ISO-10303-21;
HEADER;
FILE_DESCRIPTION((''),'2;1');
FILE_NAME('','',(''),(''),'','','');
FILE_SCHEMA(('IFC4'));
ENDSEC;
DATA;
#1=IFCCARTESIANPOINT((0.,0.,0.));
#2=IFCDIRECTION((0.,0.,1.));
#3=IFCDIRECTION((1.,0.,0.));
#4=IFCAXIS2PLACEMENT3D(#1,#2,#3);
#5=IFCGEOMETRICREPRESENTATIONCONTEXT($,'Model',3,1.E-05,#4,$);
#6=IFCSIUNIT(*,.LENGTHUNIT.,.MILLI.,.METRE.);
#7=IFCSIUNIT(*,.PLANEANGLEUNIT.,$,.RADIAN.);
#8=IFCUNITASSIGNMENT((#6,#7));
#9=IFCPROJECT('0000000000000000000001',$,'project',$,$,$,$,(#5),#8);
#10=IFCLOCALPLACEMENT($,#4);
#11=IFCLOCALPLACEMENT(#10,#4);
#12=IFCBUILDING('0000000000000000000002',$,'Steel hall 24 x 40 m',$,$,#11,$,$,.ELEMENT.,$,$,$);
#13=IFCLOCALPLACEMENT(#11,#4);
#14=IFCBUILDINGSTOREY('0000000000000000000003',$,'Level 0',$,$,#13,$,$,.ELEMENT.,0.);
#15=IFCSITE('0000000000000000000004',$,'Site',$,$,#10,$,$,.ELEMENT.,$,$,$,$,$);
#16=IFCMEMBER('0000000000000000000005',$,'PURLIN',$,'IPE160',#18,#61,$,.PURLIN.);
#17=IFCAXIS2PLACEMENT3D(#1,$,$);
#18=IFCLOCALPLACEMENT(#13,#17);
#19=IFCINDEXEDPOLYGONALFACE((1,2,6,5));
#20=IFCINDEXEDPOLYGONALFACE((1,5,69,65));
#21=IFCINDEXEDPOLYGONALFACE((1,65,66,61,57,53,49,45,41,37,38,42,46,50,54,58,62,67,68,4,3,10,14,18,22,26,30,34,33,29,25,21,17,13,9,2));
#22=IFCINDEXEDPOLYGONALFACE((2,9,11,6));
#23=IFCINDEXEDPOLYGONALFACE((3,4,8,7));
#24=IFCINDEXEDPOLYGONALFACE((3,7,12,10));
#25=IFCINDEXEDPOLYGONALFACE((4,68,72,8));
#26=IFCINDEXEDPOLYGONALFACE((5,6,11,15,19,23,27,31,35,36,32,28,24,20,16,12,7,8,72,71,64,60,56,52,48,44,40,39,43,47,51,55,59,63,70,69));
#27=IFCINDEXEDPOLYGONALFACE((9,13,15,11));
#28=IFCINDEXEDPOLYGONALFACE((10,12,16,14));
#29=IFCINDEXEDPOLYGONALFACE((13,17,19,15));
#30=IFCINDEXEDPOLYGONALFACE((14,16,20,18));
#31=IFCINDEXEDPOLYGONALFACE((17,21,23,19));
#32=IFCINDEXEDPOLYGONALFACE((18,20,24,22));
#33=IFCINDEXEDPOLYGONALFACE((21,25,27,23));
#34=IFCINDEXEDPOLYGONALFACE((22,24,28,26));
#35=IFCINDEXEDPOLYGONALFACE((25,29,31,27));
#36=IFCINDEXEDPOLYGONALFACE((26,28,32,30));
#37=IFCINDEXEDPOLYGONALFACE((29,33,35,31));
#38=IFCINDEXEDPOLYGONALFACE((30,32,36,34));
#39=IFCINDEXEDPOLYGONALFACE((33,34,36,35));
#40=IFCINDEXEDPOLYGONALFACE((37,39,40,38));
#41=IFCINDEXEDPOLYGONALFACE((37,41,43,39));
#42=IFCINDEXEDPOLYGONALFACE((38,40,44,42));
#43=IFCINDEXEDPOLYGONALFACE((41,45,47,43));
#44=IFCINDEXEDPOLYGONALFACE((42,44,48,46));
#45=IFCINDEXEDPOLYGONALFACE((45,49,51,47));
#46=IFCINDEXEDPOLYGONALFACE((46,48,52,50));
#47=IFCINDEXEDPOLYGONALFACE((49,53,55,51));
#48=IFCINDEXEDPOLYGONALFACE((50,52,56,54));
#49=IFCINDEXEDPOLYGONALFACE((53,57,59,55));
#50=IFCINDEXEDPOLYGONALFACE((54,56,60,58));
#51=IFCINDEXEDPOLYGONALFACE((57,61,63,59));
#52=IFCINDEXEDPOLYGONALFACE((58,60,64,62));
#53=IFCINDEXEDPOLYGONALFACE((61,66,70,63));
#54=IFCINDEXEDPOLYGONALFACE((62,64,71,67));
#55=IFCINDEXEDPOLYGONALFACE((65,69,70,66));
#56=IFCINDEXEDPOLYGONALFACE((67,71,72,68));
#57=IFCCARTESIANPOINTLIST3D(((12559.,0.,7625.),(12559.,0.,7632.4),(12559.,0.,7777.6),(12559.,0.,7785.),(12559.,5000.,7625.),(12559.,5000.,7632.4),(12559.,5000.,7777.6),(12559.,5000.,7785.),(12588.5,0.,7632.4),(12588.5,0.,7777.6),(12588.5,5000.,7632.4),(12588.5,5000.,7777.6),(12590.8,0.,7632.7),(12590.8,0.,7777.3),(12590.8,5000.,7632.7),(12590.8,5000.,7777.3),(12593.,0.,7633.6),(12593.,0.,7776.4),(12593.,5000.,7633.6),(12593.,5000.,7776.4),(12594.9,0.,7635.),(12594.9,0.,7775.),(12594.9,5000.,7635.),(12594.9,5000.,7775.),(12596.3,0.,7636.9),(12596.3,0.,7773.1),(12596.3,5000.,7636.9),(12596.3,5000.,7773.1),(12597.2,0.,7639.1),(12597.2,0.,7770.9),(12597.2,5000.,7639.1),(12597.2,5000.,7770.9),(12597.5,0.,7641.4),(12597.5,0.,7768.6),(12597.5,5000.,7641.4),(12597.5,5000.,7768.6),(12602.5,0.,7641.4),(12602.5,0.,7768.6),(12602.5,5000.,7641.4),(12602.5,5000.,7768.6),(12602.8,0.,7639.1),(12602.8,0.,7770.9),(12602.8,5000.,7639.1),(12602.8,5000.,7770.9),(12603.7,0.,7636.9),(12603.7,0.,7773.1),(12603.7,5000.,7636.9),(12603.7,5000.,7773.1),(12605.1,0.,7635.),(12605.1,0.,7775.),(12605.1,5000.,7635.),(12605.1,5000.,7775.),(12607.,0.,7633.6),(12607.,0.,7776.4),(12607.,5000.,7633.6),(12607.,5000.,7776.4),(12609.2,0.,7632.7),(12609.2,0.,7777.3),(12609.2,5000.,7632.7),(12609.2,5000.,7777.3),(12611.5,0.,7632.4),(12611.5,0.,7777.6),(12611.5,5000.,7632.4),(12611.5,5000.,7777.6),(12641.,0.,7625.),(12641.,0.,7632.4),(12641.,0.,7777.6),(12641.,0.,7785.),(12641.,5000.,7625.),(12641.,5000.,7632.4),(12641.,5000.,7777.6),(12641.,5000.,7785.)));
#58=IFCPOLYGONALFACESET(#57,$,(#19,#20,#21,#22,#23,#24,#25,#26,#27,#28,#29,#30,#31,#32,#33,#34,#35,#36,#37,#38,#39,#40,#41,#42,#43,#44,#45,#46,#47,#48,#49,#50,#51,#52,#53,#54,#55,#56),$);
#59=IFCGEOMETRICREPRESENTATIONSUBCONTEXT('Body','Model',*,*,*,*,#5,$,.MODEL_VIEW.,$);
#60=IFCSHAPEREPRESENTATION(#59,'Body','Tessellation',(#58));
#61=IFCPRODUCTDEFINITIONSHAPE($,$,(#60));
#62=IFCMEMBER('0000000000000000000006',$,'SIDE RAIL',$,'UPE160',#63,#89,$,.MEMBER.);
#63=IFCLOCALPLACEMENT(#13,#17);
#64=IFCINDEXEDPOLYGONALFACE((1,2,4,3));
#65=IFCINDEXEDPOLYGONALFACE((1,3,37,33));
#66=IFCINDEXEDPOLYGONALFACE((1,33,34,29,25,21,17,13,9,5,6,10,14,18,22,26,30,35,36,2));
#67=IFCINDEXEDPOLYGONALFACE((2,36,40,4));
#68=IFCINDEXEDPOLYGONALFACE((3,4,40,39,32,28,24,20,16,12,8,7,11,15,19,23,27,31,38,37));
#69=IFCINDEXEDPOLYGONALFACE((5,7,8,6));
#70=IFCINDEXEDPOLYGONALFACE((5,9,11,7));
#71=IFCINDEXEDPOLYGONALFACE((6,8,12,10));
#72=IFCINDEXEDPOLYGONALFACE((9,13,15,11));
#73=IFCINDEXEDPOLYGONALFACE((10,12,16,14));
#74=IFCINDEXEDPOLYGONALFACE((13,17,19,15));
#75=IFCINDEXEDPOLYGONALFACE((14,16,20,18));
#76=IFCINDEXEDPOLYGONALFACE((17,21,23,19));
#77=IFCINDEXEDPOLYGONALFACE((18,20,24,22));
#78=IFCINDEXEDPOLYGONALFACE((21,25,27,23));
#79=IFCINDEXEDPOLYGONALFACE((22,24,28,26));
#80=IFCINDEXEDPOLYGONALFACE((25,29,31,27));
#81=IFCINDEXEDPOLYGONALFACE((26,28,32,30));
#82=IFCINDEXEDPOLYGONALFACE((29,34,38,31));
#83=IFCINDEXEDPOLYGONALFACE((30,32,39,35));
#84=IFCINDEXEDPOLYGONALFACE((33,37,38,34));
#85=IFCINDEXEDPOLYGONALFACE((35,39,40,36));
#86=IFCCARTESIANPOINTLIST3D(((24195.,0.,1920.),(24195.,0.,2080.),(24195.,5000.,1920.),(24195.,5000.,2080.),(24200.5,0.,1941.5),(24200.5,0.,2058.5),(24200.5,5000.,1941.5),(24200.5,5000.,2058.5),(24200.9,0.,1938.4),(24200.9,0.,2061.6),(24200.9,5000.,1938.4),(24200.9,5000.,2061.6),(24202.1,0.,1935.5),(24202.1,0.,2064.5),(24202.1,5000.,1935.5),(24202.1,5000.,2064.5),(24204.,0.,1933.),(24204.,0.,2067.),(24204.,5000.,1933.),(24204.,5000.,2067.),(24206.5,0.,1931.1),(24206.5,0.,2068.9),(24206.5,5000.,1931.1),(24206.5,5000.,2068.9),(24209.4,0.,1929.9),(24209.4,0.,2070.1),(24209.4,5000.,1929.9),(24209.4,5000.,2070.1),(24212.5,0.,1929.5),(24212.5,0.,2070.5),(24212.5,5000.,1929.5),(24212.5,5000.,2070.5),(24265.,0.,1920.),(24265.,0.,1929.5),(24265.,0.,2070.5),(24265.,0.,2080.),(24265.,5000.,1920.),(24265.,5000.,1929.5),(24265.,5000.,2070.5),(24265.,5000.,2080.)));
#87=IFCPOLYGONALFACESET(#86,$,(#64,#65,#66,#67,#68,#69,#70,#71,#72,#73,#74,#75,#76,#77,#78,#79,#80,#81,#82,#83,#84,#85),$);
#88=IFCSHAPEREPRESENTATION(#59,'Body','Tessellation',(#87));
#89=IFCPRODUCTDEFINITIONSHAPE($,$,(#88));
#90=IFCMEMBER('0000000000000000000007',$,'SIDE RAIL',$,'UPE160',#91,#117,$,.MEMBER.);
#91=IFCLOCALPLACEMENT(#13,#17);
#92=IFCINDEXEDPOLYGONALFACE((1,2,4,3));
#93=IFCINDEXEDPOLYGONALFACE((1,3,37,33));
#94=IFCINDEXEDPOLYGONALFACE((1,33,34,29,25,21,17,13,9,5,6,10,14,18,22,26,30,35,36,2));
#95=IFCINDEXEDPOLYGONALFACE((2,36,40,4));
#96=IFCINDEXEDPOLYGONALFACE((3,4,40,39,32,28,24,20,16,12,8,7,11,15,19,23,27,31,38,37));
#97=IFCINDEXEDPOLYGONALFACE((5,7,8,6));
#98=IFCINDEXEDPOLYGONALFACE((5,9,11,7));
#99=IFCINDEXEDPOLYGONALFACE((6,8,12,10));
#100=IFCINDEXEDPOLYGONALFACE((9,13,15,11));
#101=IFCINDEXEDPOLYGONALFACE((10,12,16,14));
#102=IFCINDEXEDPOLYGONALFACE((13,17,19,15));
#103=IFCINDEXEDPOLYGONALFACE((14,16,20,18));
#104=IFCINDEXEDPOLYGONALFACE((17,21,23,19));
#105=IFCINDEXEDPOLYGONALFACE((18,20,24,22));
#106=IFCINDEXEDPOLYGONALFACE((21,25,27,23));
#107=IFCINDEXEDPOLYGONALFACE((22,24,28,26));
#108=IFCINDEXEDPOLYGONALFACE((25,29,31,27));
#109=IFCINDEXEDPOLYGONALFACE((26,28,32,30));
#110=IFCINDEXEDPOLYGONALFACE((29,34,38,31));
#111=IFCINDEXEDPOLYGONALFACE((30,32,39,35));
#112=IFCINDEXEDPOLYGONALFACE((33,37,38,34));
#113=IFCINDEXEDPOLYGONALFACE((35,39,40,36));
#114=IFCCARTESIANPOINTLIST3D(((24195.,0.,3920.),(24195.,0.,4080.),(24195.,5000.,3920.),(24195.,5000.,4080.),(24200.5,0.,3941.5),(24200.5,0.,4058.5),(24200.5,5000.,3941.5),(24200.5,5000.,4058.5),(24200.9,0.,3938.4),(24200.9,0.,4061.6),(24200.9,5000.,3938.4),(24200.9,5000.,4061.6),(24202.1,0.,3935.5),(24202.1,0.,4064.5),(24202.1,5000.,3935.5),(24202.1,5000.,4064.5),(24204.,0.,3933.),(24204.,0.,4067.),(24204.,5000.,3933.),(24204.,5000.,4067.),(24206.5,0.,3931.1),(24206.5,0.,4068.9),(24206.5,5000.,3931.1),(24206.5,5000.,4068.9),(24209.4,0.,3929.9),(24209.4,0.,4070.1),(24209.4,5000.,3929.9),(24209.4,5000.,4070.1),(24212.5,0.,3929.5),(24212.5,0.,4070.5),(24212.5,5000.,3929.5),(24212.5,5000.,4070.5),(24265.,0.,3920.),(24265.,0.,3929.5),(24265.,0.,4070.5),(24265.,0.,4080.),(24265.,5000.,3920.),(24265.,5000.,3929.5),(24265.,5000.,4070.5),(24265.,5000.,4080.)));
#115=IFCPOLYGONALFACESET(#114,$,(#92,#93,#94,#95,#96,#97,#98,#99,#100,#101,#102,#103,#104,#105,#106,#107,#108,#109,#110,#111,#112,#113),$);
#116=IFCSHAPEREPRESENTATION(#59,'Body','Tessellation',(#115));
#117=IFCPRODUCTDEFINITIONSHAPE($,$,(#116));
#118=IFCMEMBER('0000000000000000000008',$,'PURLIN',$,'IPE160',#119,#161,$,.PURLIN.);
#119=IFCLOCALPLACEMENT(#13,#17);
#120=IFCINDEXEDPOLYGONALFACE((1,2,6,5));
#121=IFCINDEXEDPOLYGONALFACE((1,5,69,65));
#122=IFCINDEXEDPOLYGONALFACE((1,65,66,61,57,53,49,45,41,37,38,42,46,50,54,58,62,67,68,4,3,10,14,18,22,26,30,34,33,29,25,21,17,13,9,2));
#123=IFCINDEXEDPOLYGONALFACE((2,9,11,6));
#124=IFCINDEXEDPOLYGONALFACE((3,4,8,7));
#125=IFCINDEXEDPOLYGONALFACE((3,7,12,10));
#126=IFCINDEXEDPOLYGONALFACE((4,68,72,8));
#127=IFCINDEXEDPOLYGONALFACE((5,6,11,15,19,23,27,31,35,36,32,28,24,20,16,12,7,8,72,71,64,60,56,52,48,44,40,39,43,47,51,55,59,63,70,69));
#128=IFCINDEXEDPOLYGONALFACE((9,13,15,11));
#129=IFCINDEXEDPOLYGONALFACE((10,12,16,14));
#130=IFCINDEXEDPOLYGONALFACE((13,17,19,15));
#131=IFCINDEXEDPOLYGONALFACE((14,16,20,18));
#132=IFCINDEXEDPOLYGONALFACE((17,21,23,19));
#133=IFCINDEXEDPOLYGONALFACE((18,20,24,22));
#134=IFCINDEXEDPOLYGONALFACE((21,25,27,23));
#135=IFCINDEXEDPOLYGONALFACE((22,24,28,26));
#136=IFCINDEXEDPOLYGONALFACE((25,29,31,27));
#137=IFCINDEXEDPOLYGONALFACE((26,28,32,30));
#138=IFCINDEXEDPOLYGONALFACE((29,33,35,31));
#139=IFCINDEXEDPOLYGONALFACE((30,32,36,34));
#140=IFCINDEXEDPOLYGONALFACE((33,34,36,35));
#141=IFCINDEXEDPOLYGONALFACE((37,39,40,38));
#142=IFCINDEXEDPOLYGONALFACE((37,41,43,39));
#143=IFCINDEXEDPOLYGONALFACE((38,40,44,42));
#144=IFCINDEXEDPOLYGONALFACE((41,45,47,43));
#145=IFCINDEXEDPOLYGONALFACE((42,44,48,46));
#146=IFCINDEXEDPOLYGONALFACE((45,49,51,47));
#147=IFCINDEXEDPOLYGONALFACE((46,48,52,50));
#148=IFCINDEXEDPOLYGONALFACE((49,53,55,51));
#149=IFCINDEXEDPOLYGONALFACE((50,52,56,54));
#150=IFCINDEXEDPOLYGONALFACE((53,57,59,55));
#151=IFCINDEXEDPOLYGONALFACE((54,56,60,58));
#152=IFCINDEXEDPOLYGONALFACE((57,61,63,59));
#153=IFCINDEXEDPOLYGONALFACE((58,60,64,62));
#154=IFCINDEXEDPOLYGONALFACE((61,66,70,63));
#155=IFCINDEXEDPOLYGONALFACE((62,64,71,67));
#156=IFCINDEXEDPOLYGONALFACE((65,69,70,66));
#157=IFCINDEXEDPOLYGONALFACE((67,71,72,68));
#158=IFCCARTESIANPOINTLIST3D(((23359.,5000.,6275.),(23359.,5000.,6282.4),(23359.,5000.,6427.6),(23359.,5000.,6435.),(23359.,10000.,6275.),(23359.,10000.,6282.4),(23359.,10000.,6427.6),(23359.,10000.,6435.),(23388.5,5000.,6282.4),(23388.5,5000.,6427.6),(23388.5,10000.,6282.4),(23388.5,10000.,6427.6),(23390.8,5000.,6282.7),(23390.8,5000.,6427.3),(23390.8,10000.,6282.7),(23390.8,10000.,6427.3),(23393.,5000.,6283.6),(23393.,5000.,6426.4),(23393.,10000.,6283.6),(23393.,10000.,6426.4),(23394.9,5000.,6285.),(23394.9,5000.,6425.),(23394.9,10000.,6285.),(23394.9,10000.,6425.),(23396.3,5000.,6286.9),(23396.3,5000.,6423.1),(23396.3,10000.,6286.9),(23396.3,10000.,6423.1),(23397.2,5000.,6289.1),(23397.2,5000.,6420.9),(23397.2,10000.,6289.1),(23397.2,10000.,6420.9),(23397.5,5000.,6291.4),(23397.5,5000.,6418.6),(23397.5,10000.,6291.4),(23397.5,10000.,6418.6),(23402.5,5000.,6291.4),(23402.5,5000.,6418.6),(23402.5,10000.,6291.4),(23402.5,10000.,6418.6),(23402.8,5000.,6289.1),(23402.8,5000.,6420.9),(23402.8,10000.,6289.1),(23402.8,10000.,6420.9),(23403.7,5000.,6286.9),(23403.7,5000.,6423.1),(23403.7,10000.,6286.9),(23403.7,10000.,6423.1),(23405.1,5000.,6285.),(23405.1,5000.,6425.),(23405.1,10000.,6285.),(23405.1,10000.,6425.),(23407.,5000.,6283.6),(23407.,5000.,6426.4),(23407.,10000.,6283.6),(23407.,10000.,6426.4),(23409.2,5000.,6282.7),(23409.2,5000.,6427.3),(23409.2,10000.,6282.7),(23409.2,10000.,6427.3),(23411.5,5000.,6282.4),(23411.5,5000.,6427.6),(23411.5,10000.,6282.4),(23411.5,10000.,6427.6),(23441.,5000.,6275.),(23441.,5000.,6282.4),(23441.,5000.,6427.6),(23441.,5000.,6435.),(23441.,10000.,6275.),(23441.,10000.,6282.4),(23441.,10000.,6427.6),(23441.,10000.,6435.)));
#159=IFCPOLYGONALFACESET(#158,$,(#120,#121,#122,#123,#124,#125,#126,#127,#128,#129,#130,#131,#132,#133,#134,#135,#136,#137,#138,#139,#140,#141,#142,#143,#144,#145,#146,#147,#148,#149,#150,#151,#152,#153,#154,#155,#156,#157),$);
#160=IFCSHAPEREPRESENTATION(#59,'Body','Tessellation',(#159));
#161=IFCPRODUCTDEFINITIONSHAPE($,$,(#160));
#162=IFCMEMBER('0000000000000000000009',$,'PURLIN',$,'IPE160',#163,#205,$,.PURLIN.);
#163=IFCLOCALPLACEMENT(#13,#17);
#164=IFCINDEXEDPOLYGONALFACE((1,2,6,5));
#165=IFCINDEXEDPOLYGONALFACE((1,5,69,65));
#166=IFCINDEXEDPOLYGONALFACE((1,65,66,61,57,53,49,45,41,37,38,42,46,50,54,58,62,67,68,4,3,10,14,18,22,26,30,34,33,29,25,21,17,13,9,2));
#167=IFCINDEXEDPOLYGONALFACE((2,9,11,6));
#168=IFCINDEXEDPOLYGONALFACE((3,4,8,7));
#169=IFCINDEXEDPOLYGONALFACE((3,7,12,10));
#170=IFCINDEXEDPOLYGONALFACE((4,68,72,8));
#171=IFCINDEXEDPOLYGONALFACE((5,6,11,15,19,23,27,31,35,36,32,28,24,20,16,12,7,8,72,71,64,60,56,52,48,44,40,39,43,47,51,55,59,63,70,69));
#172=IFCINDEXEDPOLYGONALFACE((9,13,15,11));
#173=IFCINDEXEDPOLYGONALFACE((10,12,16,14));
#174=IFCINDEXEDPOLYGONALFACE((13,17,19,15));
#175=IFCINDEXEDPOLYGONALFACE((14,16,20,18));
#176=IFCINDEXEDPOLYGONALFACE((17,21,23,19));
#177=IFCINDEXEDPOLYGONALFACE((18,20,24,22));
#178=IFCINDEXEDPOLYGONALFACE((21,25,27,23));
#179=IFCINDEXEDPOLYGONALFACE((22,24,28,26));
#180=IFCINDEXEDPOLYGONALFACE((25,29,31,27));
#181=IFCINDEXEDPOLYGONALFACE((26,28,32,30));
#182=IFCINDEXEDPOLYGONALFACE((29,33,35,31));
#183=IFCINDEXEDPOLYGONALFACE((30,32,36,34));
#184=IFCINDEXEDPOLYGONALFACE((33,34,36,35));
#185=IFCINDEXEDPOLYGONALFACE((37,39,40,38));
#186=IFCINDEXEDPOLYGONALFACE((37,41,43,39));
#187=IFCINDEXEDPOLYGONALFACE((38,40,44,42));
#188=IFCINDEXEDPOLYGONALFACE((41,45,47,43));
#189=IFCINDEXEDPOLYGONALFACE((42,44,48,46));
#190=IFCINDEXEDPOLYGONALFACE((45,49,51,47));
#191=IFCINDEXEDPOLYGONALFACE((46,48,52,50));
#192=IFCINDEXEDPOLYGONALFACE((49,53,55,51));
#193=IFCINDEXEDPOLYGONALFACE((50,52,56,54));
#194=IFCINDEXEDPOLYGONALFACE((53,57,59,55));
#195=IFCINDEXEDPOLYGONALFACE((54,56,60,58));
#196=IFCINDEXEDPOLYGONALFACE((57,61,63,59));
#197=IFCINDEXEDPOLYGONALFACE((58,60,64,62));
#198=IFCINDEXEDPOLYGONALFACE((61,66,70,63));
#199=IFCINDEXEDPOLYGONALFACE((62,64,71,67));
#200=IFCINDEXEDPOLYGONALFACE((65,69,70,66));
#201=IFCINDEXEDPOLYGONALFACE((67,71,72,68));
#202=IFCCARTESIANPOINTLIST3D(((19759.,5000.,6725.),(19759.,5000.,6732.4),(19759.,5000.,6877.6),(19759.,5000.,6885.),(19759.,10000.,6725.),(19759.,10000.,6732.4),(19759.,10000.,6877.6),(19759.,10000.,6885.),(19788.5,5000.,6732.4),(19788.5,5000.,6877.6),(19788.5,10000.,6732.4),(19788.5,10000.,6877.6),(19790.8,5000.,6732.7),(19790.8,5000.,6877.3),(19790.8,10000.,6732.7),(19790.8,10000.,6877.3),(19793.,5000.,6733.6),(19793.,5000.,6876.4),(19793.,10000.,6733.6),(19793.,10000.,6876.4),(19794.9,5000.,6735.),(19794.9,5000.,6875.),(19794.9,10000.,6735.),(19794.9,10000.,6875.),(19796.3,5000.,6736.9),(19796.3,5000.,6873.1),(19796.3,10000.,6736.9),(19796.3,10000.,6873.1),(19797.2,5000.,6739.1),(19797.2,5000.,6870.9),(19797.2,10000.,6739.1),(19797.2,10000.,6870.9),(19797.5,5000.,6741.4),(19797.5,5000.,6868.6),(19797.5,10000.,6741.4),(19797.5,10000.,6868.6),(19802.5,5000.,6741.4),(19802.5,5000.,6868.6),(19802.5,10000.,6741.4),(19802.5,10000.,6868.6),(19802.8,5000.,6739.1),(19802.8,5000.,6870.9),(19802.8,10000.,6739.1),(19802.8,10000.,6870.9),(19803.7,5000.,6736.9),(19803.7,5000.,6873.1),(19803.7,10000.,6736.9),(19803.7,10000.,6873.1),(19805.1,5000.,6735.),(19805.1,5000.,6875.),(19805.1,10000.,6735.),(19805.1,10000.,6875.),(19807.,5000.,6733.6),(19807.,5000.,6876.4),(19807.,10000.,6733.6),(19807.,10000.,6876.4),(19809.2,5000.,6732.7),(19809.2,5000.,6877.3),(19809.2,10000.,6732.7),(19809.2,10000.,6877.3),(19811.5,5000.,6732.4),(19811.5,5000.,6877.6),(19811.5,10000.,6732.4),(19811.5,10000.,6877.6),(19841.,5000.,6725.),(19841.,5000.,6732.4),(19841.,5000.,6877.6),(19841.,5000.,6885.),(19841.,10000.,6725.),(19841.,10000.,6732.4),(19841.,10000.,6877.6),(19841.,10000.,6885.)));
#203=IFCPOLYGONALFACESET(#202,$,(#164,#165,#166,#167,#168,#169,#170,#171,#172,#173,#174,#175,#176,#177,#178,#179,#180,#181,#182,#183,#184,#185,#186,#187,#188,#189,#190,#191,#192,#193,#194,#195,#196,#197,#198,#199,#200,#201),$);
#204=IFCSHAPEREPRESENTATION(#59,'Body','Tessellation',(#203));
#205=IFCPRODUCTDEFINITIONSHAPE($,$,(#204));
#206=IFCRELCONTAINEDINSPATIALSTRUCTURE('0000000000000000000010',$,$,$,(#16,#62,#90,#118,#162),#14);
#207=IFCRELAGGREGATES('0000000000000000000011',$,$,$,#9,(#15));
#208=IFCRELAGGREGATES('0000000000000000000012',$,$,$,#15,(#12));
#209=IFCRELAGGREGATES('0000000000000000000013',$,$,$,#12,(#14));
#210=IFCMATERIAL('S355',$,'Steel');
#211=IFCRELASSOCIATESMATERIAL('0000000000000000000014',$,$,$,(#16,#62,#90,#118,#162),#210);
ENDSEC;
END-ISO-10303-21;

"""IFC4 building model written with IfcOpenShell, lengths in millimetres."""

from ifc_helpers import new_model, si_unit, frame, origin_with_axes, place, context, subcontext, project, spatial, i_section, u_section, extrude, material, element, save


model = new_model("IFC4")

# Units and contexts
model_context = context("Model", 3, precision=1e-05, world=origin_with_axes())
body_context = subcontext(model_context, "Body", "Model", "MODEL_VIEW")
ifc_project = project(units=[si_unit("LENGTHUNIT", "METRE", prefix="MILLI"), si_unit("PLANEANGLEUNIT", "RADIAN")], contexts=[model_context])

# Site, building, storey
site_placement = place(None, origin_with_axes())
site = spatial("IfcSite", under=ifc_project, at=site_placement, Name="Site", CompositionType="ELEMENT")
building_placement = place(site_placement, origin_with_axes())
building = spatial("IfcBuilding", under=site, at=building_placement, Name="Steel hall 24 x 40 m", CompositionType="ELEMENT")
storey_placement = place(building_placement, origin_with_axes())
storey = spatial("IfcBuildingStorey", under=building, at=storey_placement, Name="Level 0", CompositionType="ELEMENT", Elevation=0.0)

# Shared definitions
ifc_material = material(Name="S355", Category="Steel")

# Members
for number, where, z_axis, x_axis, name in (
    (1, (12600.0, 0.0, 7705.0), (0.0, 1.0, 0.0), (1.0, 0.0, 0.0), "PURLIN"),
):
    element("IfcMember", number, at=place(storey_placement, frame(where, z_axis=z_axis, x_axis=x_axis)), inside=storey, material=ifc_material, Name=name, ObjectType="IPE160", PredefinedType="PURLIN", context=body_context, shape_type="SweptSolid", body=[
        extrude(i_section(OverallWidth=82.0, OverallDepth=160.0, WebThickness=5.0, FlangeThickness=7.4, FilletRadius=9.0), origin_with_axes(), (0.0, 0.0, 1.0), 5000.0),
    ])
for number, where, z_axis, x_axis, name in (
    (2, (24230.0, 0.0, 2000.0), (0.0, 1.0, 0.0), (1.0, 0.0, 0.0), "SIDE RAIL"),
    (3, (24230.0, 0.0, 4000.0), (0.0, 1.0, 0.0), (1.0, 0.0, 0.0), "SIDE RAIL"),
):
    element("IfcMember", number, at=place(storey_placement, frame(where, z_axis=z_axis, x_axis=x_axis)), inside=storey, material=ifc_material, Name=name, ObjectType="UPE160", PredefinedType="MEMBER", context=body_context, shape_type="SweptSolid", body=[
        extrude(u_section(Depth=160.0, FlangeWidth=70.0, WebThickness=5.5, FlangeThickness=9.5, FilletRadius=12.0), origin_with_axes(), (0.0, 0.0, 1.0), 5000.0),
    ])
for number, where, z_axis, x_axis, name in (
    (4, (23400.0, 5000.0, 6355.0), (0.0, 1.0, 0.0), (1.0, 0.0, 0.0), "PURLIN"),
    (5, (19800.0, 5000.0, 6805.0), (0.0, 1.0, 0.0), (1.0, 0.0, 0.0), "PURLIN"),
):
    element("IfcMember", number, at=place(storey_placement, frame(where, z_axis=z_axis, x_axis=x_axis)), inside=storey, material=ifc_material, Name=name, ObjectType="IPE160", PredefinedType="PURLIN", context=body_context, shape_type="SweptSolid", body=[
        extrude(i_section(OverallWidth=82.0, OverallDepth=160.0, WebThickness=5.0, FlangeThickness=7.4, FilletRadius=9.0), origin_with_axes(), (0.0, 0.0, 1.0), 5000.0),
    ])

save(model, "model.ifc")
